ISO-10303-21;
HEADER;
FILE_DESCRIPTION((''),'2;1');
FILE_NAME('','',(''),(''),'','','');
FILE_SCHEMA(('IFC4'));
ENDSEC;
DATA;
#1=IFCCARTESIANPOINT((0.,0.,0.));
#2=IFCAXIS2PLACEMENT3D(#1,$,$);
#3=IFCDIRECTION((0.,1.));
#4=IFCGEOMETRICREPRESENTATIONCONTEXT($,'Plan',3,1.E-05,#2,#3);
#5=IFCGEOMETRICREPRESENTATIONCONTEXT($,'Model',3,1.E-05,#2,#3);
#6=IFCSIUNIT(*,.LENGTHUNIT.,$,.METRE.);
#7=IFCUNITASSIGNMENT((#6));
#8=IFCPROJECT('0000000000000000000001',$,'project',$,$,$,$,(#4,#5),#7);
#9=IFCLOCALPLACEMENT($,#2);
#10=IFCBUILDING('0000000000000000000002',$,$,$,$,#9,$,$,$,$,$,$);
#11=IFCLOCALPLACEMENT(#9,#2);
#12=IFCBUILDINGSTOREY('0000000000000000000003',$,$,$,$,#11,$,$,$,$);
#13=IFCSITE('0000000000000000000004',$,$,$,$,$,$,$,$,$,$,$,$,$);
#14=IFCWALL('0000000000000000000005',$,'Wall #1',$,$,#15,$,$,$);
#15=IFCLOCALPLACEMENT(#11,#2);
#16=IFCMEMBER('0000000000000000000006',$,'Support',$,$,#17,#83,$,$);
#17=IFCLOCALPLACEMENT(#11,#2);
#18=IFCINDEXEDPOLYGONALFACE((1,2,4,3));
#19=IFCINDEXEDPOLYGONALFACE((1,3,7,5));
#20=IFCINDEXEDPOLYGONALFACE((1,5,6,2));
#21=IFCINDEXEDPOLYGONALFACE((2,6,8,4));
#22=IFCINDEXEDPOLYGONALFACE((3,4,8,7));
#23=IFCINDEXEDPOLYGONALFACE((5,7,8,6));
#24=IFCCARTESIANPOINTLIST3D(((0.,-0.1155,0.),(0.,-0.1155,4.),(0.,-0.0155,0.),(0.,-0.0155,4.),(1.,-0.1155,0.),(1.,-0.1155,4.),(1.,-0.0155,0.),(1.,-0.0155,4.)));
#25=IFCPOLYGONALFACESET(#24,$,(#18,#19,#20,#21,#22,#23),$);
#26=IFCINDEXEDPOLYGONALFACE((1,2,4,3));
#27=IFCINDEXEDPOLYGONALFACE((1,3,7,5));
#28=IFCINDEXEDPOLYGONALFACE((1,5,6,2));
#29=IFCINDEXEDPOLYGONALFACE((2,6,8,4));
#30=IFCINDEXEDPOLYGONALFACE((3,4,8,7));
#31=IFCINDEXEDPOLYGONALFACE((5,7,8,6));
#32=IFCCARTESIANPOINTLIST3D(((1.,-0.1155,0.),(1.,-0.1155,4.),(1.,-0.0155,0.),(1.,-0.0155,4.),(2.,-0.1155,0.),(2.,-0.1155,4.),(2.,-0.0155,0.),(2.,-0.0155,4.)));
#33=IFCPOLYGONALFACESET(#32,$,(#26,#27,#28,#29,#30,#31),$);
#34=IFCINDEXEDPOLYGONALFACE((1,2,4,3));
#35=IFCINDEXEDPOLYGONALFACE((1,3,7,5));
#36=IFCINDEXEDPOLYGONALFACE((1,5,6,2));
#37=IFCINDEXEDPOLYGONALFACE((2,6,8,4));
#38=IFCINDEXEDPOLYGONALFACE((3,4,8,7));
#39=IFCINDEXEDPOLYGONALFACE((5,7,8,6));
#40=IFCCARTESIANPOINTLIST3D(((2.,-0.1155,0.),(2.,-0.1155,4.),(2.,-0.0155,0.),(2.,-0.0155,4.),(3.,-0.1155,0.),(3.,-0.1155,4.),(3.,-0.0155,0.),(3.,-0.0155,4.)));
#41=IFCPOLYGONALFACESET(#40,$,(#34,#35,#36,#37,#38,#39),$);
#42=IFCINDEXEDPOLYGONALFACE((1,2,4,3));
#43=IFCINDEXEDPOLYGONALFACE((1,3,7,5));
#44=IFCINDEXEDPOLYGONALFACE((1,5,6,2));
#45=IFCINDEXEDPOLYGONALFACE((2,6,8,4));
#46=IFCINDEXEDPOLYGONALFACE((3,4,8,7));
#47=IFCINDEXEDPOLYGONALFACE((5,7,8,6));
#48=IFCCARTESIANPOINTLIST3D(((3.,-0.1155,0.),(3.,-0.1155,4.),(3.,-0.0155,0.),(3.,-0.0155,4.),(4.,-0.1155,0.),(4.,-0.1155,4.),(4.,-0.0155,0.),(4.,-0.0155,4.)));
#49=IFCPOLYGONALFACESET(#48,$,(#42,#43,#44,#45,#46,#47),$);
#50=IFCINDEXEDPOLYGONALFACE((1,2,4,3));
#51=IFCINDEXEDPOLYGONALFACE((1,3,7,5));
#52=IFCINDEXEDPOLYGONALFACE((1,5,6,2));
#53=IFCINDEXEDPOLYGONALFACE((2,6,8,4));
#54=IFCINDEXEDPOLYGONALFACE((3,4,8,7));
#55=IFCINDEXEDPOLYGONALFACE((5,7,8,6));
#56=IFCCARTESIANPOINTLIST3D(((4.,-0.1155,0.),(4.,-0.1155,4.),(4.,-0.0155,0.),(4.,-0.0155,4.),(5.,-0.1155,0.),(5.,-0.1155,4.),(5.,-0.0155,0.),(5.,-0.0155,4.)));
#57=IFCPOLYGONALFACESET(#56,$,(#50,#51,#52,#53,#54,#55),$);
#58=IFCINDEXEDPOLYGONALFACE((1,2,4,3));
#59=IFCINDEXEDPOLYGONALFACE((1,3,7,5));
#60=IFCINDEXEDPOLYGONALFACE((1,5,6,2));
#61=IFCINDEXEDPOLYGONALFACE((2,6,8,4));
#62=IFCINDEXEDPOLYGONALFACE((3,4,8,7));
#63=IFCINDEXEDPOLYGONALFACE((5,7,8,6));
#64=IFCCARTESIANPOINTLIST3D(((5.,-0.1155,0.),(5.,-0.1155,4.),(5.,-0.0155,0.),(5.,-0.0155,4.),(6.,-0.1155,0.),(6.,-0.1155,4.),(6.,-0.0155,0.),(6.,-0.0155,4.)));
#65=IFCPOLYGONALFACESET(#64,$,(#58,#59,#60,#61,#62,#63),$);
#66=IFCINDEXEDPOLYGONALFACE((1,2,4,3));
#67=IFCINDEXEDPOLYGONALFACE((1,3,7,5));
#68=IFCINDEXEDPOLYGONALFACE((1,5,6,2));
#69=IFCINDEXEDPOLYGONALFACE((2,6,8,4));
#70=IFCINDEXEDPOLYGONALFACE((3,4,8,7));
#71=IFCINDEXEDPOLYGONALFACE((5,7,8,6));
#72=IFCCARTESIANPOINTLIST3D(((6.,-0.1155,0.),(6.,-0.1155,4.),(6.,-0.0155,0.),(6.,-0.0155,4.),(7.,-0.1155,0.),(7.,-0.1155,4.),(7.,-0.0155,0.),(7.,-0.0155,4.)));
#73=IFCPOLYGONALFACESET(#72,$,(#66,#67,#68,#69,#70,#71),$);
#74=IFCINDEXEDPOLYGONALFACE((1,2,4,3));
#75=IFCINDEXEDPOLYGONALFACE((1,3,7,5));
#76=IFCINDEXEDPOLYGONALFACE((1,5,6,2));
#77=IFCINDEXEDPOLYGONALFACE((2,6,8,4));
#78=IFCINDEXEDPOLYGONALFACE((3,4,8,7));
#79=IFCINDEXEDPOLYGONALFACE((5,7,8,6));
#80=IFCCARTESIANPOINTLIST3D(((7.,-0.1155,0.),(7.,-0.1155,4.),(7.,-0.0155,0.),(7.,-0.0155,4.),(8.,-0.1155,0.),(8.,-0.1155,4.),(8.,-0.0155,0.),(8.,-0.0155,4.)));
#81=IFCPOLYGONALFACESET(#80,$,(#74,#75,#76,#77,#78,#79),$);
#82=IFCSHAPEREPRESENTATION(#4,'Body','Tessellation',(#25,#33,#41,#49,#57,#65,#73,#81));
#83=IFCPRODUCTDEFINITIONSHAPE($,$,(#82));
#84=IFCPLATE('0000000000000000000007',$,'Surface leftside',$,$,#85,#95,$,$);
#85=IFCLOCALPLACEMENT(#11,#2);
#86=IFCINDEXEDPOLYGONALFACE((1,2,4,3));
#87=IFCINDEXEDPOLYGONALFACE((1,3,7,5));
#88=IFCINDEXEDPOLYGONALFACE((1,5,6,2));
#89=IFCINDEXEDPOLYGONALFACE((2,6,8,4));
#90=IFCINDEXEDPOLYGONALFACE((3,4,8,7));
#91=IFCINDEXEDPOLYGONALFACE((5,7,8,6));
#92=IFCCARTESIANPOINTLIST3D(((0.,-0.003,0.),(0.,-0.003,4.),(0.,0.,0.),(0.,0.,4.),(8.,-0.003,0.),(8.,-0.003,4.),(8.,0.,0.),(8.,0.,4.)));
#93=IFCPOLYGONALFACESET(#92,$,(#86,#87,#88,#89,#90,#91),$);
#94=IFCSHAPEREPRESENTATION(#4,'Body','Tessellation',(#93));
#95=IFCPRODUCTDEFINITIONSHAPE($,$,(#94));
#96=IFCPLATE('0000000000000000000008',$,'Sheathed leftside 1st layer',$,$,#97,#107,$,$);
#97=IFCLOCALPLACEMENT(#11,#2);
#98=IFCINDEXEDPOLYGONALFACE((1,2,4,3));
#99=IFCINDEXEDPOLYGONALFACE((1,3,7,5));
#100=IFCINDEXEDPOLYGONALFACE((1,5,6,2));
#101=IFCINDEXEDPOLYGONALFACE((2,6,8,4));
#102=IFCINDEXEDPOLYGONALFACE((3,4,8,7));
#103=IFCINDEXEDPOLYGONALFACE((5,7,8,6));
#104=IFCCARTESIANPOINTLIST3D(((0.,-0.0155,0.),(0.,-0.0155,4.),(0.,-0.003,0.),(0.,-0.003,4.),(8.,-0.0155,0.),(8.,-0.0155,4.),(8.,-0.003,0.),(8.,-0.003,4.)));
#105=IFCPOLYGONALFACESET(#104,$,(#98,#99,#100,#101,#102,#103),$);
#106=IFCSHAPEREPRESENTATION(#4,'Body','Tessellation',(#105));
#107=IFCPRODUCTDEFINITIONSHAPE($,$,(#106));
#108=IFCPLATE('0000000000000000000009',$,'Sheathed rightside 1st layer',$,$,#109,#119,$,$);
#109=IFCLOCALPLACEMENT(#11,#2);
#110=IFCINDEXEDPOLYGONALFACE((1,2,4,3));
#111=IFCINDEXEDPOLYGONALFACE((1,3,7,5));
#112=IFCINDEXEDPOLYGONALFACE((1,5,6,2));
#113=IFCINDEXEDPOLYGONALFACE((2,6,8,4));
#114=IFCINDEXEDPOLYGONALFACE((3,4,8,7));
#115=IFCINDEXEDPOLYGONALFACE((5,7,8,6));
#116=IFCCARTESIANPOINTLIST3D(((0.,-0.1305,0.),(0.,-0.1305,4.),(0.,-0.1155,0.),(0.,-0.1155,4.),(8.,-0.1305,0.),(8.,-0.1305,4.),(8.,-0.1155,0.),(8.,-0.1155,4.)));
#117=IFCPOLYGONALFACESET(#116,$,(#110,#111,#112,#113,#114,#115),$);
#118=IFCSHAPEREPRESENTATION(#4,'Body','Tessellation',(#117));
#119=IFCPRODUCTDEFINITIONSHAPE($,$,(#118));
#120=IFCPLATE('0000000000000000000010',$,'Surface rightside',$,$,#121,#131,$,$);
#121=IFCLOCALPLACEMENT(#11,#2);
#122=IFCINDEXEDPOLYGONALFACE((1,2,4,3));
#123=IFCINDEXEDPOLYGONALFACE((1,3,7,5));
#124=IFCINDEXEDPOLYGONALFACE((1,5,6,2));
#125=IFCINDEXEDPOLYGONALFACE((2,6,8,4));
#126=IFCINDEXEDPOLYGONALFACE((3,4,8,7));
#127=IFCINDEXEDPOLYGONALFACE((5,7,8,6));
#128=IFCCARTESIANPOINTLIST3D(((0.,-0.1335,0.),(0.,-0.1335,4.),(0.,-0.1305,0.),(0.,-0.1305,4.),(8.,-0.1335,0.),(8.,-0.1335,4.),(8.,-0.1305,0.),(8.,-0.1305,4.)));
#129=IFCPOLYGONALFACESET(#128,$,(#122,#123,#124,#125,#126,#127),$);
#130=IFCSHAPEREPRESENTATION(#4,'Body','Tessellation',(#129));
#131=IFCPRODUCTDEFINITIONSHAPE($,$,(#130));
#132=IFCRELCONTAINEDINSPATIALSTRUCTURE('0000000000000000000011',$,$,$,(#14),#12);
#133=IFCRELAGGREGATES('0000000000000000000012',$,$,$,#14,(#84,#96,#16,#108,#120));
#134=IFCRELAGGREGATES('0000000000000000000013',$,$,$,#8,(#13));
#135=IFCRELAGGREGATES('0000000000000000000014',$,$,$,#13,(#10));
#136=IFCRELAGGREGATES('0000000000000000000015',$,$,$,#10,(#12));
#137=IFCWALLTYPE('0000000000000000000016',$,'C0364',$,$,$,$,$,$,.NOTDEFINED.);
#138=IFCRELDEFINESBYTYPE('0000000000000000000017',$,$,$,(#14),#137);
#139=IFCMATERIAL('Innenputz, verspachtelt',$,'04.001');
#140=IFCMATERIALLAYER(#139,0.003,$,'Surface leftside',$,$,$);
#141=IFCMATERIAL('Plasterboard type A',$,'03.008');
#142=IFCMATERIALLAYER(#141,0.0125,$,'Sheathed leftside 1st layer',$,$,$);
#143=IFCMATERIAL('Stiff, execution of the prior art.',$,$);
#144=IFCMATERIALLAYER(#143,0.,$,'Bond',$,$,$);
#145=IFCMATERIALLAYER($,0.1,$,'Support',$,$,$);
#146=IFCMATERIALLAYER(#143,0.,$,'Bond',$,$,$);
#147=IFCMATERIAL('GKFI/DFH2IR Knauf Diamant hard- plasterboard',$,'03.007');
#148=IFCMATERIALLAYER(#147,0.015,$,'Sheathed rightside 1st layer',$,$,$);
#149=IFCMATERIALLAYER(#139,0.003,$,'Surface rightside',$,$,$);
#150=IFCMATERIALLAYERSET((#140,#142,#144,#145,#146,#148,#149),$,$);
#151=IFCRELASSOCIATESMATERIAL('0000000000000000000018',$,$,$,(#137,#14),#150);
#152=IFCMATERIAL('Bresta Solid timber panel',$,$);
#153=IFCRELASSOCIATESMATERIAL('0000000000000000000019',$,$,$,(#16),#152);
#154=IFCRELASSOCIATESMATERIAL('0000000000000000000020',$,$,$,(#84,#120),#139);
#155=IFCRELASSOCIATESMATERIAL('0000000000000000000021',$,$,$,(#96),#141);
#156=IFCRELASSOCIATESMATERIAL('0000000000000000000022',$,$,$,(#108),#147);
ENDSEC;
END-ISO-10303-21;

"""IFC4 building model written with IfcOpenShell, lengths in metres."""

from ifc_helpers import new_model, si_unit, direction, frame, frame_2d, origin, origin_with_axes, place, context, project, spatial, rectangle, extrude, material, layer, layer_set, type_object, element, aggregate, save


model = new_model("IFC4")

# Units and contexts
plan_context = context("Plan", 3, precision=1e-05, world=origin(), true_north=direction((0.0, 1.0)))
model_context = context("Model", 3, precision=1e-05, world=origin(), true_north=direction((0.0, 1.0)))
ifc_project = project(units=[si_unit("LENGTHUNIT", "METRE")], contexts=[plan_context, model_context])

# Site, building, storey
site = spatial("IfcSite", under=ifc_project)
building_placement = place(None, origin())
building = spatial("IfcBuilding", under=site, at=building_placement)
storey_placement = place(building_placement, origin())
storey = spatial("IfcBuildingStorey", under=building, at=storey_placement)

# Wall, member, plates
ifc_material_1 = material(Name="Innenputz, verspachtelt", Category="04.001")
ifc_layer_1 = layer(ifc_material_1, 0.003, Name="Surface leftside")
ifc_material_2 = material(Name="Plasterboard type A", Category="03.008")
ifc_layer_2 = layer(ifc_material_2, 0.0125, Name="Sheathed leftside 1st layer")
ifc_material_3 = material(Name="Stiff, execution of the prior art.")
ifc_layer_3 = layer(ifc_material_3, 0.0, Name="Bond")
ifc_layer_4 = layer(None, 0.1, Name="Support")
ifc_layer_5 = layer(ifc_material_3, 0.0, Name="Bond")
ifc_material_4 = material(Name="GKFI/DFH2IR Knauf Diamant hard- plasterboard", Category="03.007")
ifc_layer_6 = layer(ifc_material_4, 0.015, Name="Sheathed rightside 1st layer")
ifc_layer_7 = layer(ifc_material_1, 0.003, Name="Surface rightside")
ifc_layer_set = layer_set([ifc_layer_1, ifc_layer_2, ifc_layer_3, ifc_layer_4, ifc_layer_5, ifc_layer_6, ifc_layer_7])
wall_type = type_object("IfcWallType", Name="C0364", PredefinedType="NOTDEFINED", material=ifc_layer_set)
wall_placement = place(None, frame((0.0, 0.0, 0.0), z_axis=(0.0, -1.0, 0.0), x_axis=(1.0, 0.0, 0.0)))
wall = element("IfcWall", 1, at=wall_placement, inside=storey, type_object=wall_type, material=ifc_layer_set, Name="Wall #1")
ifc_material_5 = material(Name="Bresta Solid timber panel")
member_placement = place(wall_placement, origin())
member = element("IfcMember", 2, at=member_placement, material=ifc_material_5, Name="Support", context=plan_context, shape_type="SweptSolid", body=[
    extrude(rectangle(XDim=1.0, YDim=0.1, at=frame_2d((0.5, 0.05), x_axis=(1.0, 0.0))), frame((0.0, 4.0, 0.0155), z_axis=(0.0, -1.0, 0.0), x_axis=(1.0, 0.0, 0.0)), (0.0, 0.0, 1.0), 4.0),
    extrude(rectangle(XDim=1.0, YDim=0.1, at=frame_2d((0.5, 0.05), x_axis=(1.0, 0.0))), frame((1.0, 4.0, 0.0155), z_axis=(0.0, -1.0, 0.0), x_axis=(1.0, 0.0, 0.0)), (0.0, 0.0, 1.0), 4.0),
    extrude(rectangle(XDim=1.0, YDim=0.1, at=frame_2d((0.5, 0.05), x_axis=(1.0, 0.0))), frame((2.0, 4.0, 0.0155), z_axis=(0.0, -1.0, 0.0), x_axis=(1.0, 0.0, 0.0)), (0.0, 0.0, 1.0), 4.0),
    extrude(rectangle(XDim=1.0, YDim=0.1, at=frame_2d((0.5, 0.05), x_axis=(1.0, 0.0))), frame((3.0, 4.0, 0.0155), z_axis=(0.0, -1.0, 0.0), x_axis=(1.0, 0.0, 0.0)), (0.0, 0.0, 1.0), 4.0),
    extrude(rectangle(XDim=1.0, YDim=0.1, at=frame_2d((0.5, 0.05), x_axis=(1.0, 0.0))), frame((4.0, 4.0, 0.0155), z_axis=(0.0, -1.0, 0.0), x_axis=(1.0, 0.0, 0.0)), (0.0, 0.0, 1.0), 4.0),
    extrude(rectangle(XDim=1.0, YDim=0.1, at=frame_2d((0.5, 0.05), x_axis=(1.0, 0.0))), frame((5.0, 4.0, 0.0155), z_axis=(0.0, -1.0, 0.0), x_axis=(1.0, 0.0, 0.0)), (0.0, 0.0, 1.0), 4.0),
    extrude(rectangle(XDim=1.0, YDim=0.1, at=frame_2d((0.5, 0.05), x_axis=(1.0, 0.0))), frame((6.0, 4.0, 0.0155), z_axis=(0.0, -1.0, 0.0), x_axis=(1.0, 0.0, 0.0)), (0.0, 0.0, 1.0), 4.0),
    extrude(rectangle(XDim=1.0, YDim=0.1, at=frame_2d((0.5, 0.05), x_axis=(1.0, 0.0))), frame((7.0, 4.0, 0.0155), z_axis=(0.0, -1.0, 0.0), x_axis=(1.0, 0.0, 0.0)), (0.0, 0.0, 1.0), 4.0),
])
plate_1_placement = place(wall_placement, origin())
plate_1 = element("IfcPlate", 3, at=plate_1_placement, material=ifc_material_1, Name="Surface leftside", context=plan_context, shape_type="SweptSolid", body=[
    extrude(rectangle(XDim=8.0, YDim=4.0, at=frame_2d((4.0, 2.0), x_axis=(1.0, 0.0))), origin_with_axes(), (0.0, 0.0, 1.0), 0.003),
])
plate_2_placement = place(wall_placement, origin())
plate_2 = element("IfcPlate", 4, at=plate_2_placement, material=ifc_material_2, Name="Sheathed leftside 1st layer", context=plan_context, shape_type="SweptSolid", body=[
    extrude(rectangle(XDim=8.0, YDim=4.0, at=frame_2d((4.0, 2.0), x_axis=(1.0, 0.0))), frame((0.0, 0.0, 0.003), z_axis=(0.0, 0.0, 1.0), x_axis=(1.0, 0.0, 0.0)), (0.0, 0.0, 1.0), 0.0125),
])
plate_3_placement = place(wall_placement, origin())
plate_3 = element("IfcPlate", 5, at=plate_3_placement, material=ifc_material_4, Name="Sheathed rightside 1st layer", context=plan_context, shape_type="SweptSolid", body=[
    extrude(rectangle(XDim=8.0, YDim=4.0, at=frame_2d((4.0, 2.0), x_axis=(1.0, 0.0))), frame((0.0, 0.0, 0.1155), z_axis=(0.0, 0.0, 1.0), x_axis=(1.0, 0.0, 0.0)), (0.0, 0.0, 1.0), 0.015),
])
plate_4_placement = place(wall_placement, origin())
plate_4 = element("IfcPlate", 6, at=plate_4_placement, material=ifc_material_1, Name="Surface rightside", context=plan_context, shape_type="SweptSolid", body=[
    extrude(rectangle(XDim=8.0, YDim=4.0, at=frame_2d((4.0, 2.0), x_axis=(1.0, 0.0))), frame((0.0, 0.0, 0.1305), z_axis=(0.0, 0.0, 1.0), x_axis=(1.0, 0.0, 0.0)), (0.0, 0.0, 1.0), 0.003),
])
aggregate(wall, [plate_1, plate_2, member, plate_3, plate_4])

save(model, "model.ifc")
